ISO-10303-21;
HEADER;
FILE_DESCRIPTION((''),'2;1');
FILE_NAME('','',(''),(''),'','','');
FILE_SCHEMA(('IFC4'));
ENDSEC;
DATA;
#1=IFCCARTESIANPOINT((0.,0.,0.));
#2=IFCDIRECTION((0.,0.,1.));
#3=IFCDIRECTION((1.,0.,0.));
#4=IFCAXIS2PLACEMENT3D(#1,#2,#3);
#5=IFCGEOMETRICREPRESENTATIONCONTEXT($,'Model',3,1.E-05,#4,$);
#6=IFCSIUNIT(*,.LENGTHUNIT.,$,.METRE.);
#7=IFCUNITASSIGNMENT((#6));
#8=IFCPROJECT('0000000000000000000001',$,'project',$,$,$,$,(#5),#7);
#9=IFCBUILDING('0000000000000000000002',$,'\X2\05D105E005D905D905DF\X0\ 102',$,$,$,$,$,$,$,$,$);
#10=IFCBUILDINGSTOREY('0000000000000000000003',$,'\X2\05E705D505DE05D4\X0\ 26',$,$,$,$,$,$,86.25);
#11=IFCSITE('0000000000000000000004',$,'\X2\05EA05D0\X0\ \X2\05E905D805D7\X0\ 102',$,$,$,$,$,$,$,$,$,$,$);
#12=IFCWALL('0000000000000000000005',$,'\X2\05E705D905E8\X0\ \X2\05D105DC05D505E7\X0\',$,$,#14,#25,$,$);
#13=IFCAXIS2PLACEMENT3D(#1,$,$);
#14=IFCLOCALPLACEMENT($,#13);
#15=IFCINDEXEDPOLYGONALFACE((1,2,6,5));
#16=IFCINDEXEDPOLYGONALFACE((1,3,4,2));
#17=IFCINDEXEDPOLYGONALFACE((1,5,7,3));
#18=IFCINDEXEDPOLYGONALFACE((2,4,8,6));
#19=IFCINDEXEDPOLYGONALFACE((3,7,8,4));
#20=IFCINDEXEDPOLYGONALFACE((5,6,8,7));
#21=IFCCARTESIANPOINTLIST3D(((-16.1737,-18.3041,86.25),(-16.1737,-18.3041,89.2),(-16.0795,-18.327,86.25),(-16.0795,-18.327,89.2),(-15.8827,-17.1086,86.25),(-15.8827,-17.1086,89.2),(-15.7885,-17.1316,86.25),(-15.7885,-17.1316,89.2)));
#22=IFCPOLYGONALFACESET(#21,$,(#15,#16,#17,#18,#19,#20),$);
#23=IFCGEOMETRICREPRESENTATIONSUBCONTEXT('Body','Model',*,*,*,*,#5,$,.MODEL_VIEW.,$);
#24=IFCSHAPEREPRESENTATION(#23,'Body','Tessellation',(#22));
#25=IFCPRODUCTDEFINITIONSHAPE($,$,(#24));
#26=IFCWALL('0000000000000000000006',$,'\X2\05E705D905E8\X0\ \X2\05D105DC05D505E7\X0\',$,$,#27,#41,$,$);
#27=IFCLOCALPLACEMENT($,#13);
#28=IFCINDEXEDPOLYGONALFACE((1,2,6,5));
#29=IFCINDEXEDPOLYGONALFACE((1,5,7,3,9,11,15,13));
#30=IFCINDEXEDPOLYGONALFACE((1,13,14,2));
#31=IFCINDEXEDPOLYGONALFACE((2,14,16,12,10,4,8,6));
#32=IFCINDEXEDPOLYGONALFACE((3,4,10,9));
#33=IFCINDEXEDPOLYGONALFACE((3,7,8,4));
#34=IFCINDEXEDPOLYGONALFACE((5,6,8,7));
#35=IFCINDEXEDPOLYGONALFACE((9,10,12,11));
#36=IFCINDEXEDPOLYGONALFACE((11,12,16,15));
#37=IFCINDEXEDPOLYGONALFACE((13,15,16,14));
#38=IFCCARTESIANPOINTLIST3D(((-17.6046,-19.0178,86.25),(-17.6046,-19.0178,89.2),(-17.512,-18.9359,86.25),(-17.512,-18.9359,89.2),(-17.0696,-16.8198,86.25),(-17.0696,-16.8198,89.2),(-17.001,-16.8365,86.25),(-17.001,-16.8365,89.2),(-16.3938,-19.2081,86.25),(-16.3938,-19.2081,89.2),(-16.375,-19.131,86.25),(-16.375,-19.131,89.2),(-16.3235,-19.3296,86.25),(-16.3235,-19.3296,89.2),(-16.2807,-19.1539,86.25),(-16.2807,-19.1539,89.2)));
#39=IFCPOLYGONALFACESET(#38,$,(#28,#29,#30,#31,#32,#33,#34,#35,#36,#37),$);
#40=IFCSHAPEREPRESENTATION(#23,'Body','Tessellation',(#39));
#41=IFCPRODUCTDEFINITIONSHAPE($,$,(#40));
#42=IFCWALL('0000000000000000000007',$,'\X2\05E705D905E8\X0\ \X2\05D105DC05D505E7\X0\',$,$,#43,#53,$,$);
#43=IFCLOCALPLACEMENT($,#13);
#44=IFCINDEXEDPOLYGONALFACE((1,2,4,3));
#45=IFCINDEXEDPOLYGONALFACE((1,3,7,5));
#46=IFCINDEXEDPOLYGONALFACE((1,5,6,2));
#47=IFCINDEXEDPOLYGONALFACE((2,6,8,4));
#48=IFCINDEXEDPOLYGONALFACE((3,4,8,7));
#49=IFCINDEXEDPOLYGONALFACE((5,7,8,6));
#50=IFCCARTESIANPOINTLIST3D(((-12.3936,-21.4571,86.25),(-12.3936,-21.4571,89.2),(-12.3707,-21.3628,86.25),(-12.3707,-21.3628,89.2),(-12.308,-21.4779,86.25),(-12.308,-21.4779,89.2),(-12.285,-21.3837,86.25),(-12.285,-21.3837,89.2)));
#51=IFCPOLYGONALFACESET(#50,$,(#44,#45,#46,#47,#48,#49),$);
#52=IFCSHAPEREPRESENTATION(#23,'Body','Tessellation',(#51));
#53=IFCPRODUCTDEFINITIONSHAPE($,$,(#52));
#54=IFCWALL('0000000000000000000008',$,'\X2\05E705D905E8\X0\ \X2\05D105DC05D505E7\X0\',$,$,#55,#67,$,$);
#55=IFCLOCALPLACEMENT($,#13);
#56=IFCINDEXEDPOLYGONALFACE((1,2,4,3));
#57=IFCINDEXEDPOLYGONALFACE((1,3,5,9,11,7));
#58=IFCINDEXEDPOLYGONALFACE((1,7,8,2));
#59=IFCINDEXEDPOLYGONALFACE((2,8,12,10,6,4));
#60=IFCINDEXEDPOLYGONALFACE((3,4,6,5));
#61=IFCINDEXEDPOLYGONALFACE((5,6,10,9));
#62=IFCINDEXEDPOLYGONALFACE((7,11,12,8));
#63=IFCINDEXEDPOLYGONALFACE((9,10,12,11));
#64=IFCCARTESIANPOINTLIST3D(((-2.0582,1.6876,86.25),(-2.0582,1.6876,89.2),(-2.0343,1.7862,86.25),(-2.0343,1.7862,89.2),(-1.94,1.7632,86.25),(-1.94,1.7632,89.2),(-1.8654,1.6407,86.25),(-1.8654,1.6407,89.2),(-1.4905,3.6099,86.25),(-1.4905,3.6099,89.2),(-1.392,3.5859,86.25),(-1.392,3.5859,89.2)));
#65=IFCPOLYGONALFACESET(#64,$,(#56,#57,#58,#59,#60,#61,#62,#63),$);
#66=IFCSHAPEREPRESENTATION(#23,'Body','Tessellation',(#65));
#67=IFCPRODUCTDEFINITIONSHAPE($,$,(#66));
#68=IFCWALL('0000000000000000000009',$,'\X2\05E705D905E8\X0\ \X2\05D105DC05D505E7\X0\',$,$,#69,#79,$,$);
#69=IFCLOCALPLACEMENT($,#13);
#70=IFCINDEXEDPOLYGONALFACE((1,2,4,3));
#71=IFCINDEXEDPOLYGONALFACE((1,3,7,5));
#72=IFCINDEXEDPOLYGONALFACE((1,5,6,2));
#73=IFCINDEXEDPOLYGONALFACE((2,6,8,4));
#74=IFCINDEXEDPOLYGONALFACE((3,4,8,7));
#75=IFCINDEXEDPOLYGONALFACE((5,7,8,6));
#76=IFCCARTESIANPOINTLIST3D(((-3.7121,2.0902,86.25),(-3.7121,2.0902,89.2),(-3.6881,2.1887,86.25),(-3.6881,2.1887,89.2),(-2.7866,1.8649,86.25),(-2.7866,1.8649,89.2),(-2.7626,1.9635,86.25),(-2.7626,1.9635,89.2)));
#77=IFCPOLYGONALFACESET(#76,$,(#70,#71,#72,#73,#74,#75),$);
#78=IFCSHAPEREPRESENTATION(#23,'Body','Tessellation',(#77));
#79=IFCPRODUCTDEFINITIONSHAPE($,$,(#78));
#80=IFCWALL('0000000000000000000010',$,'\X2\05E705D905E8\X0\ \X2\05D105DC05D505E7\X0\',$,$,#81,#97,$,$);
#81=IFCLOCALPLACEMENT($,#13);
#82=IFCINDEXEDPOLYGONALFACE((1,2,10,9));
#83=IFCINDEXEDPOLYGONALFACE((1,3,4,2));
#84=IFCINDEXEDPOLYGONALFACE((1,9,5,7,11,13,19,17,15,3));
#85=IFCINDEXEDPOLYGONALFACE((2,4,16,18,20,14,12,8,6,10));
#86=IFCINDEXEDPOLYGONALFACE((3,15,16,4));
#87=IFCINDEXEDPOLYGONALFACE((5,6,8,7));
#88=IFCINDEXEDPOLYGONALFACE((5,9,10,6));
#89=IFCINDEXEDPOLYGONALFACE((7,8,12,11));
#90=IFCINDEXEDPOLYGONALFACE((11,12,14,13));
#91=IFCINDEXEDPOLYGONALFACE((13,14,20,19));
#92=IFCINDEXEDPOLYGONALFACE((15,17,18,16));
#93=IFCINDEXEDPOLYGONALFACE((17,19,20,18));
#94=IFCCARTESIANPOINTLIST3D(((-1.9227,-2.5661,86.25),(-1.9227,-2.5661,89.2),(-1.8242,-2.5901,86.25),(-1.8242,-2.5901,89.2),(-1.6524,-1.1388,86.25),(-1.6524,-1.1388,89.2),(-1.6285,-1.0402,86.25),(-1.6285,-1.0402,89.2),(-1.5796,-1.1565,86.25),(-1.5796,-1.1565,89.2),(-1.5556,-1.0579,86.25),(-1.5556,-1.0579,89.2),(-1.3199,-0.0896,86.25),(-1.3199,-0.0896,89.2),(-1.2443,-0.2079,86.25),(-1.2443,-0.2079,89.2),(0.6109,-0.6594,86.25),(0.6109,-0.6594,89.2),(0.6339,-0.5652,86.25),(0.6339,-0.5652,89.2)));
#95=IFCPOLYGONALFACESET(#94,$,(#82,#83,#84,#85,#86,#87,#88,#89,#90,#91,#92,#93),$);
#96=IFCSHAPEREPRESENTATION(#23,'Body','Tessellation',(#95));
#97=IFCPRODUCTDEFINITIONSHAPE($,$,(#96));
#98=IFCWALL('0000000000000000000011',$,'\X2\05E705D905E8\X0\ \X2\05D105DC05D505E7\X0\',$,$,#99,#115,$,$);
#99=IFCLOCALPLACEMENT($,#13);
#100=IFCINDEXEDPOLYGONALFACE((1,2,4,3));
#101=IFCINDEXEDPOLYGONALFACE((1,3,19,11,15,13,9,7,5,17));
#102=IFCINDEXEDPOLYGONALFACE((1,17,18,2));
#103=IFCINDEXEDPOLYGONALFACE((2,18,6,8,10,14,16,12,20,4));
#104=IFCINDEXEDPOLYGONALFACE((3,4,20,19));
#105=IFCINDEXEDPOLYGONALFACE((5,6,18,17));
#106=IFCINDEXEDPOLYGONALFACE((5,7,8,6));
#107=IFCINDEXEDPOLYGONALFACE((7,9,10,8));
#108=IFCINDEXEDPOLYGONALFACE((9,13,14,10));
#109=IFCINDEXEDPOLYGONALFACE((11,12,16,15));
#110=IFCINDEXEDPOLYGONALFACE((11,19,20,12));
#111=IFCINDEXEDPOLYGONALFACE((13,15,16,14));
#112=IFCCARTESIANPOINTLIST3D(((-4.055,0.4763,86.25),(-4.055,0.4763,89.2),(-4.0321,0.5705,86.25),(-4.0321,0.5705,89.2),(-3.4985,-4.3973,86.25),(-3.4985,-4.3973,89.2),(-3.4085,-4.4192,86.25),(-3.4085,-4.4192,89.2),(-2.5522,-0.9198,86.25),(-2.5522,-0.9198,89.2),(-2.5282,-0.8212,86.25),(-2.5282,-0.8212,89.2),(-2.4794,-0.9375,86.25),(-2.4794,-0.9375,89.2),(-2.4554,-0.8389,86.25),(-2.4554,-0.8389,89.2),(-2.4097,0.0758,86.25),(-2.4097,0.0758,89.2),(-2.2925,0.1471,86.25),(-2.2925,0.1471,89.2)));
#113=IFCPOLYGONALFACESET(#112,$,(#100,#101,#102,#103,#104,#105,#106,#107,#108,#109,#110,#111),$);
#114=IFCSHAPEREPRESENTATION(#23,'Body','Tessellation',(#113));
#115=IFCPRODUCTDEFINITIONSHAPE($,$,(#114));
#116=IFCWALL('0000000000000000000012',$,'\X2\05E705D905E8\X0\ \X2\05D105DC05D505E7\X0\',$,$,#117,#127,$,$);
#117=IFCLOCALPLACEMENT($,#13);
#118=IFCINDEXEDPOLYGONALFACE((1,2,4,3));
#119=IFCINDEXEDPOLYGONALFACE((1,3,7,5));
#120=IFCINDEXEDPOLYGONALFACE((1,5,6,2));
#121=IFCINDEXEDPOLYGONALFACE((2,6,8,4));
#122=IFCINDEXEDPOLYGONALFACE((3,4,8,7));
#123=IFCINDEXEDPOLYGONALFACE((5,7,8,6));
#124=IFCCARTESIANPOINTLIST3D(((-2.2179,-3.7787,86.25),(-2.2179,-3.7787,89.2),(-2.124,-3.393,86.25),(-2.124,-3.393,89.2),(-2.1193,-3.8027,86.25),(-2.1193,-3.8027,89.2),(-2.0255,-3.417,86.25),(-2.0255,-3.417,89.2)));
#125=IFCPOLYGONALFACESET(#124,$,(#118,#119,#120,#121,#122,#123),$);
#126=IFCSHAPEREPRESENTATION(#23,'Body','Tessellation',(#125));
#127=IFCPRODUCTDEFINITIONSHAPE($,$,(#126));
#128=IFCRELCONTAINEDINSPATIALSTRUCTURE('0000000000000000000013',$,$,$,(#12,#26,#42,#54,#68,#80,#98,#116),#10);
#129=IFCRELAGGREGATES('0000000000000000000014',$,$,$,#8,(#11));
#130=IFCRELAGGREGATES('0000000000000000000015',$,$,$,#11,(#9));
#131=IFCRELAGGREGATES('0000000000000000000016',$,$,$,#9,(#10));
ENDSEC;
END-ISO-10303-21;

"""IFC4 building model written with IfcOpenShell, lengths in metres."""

from ifc_helpers import new_model, si_unit, frame, origin_with_axes, context, subcontext, project, spatial, polyline, outline, extrude, element, save


model = new_model("IFC4")

# Units and contexts
model_context = context("Model", 3, precision=1e-05, world=origin_with_axes())
body_context = subcontext(model_context, "Body", "Model", "MODEL_VIEW")
ifc_project = project(units=[si_unit("LENGTHUNIT", "METRE")], contexts=[model_context])

# Site, building, storey
site = spatial("IfcSite", under=ifc_project, Name="תא שטח 102")
building = spatial("IfcBuilding", under=site, Name="בניין 102")
storey = spatial("IfcBuildingStorey", under=building, Name="קומה 26", Elevation=86.25)

# Walls
element("IfcWall", 1, inside=storey, Name="קיר בלוק", context=body_context, shape_type="SweptSolid", body=[
    extrude(outline(polyline([(-16.1737, -18.3041), (-16.0795, -18.327), (-15.7885, -17.1316), (-15.8827, -17.1086), (-16.1737, -18.3041)])), frame((0.0, 0.0, 86.25)), (0.0, 0.0, 1.0), 2.95),
])
element("IfcWall", 2, inside=storey, Name="קיר בלוק", context=body_context, shape_type="SweptSolid", body=[
    extrude(outline(polyline([(-17.6046, -19.0178), (-16.3235, -19.3296), (-16.2807, -19.1539), (-16.375, -19.131), (-16.3938, -19.2081), (-17.512, -18.9359), (-17.001, -16.8365), (-17.0696, -16.8198), (-17.6046, -19.0178)])), frame((0.0, 0.0, 86.25)), (0.0, 0.0, 1.0), 2.95),
])
element("IfcWall", 3, inside=storey, Name="קיר בלוק", context=body_context, shape_type="SweptSolid", body=[
    extrude(outline(polyline([(-12.285, -21.3837), (-12.3707, -21.3628), (-12.3936, -21.4571), (-12.308, -21.4779), (-12.285, -21.3837)])), frame((0.0, 0.0, 86.25)), (0.0, 0.0, 1.0), 2.95),
])
element("IfcWall", 4, inside=storey, Name="קיר בלוק", context=body_context, shape_type="SweptSolid", body=[
    extrude(outline(polyline([(-2.0582, 1.6876), (-1.8654, 1.6407), (-1.392, 3.5859), (-1.4905, 3.6099), (-1.94, 1.7632), (-2.0343, 1.7862), (-2.0582, 1.6876)])), frame((0.0, 0.0, 86.25)), (0.0, 0.0, 1.0), 2.95),
])
element("IfcWall", 5, inside=storey, Name="קיר בלוק", context=body_context, shape_type="SweptSolid", body=[
    extrude(outline(polyline([(-2.7626, 1.9635), (-3.6881, 2.1887), (-3.7121, 2.0902), (-2.7866, 1.8649), (-2.7626, 1.9635)])), frame((0.0, 0.0, 86.25)), (0.0, 0.0, 1.0), 2.95),
])
element("IfcWall", 6, inside=storey, Name="קיר בלוק", context=body_context, shape_type="SweptSolid", body=[
    extrude(outline(polyline([(-1.6524, -1.1388), (-1.5796, -1.1565), (-1.9227, -2.5661), (-1.8242, -2.5901), (-1.2443, -0.2079), (0.6109, -0.6594), (0.6339, -0.5652), (-1.3199, -0.0896), (-1.5556, -1.0579), (-1.6285, -1.0402), (-1.6524, -1.1388)])), frame((0.0, 0.0, 86.25)), (0.0, 0.0, 1.0), 2.95),
])
element("IfcWall", 7, inside=storey, Name="קיר בלוק", context=body_context, shape_type="SweptSolid", body=[
    extrude(outline(polyline([(-3.4085, -4.4192), (-2.5522, -0.9198), (-2.4794, -0.9375), (-2.4554, -0.8389), (-2.5282, -0.8212), (-2.2925, 0.1471), (-4.0321, 0.5705), (-4.055, 0.4763), (-2.4097, 0.0758), (-3.4985, -4.3973), (-3.4085, -4.4192)])), frame((0.0, 0.0, 86.25)), (0.0, 0.0, 1.0), 2.95),
])
element("IfcWall", 8, inside=storey, Name="קיר בלוק", context=body_context, shape_type="SweptSolid", body=[
    extrude(outline(polyline([(-2.0255, -3.417), (-2.124, -3.393), (-2.2179, -3.7787), (-2.1193, -3.8027), (-2.0255, -3.417)])), frame((0.0, 0.0, 86.25)), (0.0, 0.0, 1.0), 2.95),
])

save(model, "model.ifc")
